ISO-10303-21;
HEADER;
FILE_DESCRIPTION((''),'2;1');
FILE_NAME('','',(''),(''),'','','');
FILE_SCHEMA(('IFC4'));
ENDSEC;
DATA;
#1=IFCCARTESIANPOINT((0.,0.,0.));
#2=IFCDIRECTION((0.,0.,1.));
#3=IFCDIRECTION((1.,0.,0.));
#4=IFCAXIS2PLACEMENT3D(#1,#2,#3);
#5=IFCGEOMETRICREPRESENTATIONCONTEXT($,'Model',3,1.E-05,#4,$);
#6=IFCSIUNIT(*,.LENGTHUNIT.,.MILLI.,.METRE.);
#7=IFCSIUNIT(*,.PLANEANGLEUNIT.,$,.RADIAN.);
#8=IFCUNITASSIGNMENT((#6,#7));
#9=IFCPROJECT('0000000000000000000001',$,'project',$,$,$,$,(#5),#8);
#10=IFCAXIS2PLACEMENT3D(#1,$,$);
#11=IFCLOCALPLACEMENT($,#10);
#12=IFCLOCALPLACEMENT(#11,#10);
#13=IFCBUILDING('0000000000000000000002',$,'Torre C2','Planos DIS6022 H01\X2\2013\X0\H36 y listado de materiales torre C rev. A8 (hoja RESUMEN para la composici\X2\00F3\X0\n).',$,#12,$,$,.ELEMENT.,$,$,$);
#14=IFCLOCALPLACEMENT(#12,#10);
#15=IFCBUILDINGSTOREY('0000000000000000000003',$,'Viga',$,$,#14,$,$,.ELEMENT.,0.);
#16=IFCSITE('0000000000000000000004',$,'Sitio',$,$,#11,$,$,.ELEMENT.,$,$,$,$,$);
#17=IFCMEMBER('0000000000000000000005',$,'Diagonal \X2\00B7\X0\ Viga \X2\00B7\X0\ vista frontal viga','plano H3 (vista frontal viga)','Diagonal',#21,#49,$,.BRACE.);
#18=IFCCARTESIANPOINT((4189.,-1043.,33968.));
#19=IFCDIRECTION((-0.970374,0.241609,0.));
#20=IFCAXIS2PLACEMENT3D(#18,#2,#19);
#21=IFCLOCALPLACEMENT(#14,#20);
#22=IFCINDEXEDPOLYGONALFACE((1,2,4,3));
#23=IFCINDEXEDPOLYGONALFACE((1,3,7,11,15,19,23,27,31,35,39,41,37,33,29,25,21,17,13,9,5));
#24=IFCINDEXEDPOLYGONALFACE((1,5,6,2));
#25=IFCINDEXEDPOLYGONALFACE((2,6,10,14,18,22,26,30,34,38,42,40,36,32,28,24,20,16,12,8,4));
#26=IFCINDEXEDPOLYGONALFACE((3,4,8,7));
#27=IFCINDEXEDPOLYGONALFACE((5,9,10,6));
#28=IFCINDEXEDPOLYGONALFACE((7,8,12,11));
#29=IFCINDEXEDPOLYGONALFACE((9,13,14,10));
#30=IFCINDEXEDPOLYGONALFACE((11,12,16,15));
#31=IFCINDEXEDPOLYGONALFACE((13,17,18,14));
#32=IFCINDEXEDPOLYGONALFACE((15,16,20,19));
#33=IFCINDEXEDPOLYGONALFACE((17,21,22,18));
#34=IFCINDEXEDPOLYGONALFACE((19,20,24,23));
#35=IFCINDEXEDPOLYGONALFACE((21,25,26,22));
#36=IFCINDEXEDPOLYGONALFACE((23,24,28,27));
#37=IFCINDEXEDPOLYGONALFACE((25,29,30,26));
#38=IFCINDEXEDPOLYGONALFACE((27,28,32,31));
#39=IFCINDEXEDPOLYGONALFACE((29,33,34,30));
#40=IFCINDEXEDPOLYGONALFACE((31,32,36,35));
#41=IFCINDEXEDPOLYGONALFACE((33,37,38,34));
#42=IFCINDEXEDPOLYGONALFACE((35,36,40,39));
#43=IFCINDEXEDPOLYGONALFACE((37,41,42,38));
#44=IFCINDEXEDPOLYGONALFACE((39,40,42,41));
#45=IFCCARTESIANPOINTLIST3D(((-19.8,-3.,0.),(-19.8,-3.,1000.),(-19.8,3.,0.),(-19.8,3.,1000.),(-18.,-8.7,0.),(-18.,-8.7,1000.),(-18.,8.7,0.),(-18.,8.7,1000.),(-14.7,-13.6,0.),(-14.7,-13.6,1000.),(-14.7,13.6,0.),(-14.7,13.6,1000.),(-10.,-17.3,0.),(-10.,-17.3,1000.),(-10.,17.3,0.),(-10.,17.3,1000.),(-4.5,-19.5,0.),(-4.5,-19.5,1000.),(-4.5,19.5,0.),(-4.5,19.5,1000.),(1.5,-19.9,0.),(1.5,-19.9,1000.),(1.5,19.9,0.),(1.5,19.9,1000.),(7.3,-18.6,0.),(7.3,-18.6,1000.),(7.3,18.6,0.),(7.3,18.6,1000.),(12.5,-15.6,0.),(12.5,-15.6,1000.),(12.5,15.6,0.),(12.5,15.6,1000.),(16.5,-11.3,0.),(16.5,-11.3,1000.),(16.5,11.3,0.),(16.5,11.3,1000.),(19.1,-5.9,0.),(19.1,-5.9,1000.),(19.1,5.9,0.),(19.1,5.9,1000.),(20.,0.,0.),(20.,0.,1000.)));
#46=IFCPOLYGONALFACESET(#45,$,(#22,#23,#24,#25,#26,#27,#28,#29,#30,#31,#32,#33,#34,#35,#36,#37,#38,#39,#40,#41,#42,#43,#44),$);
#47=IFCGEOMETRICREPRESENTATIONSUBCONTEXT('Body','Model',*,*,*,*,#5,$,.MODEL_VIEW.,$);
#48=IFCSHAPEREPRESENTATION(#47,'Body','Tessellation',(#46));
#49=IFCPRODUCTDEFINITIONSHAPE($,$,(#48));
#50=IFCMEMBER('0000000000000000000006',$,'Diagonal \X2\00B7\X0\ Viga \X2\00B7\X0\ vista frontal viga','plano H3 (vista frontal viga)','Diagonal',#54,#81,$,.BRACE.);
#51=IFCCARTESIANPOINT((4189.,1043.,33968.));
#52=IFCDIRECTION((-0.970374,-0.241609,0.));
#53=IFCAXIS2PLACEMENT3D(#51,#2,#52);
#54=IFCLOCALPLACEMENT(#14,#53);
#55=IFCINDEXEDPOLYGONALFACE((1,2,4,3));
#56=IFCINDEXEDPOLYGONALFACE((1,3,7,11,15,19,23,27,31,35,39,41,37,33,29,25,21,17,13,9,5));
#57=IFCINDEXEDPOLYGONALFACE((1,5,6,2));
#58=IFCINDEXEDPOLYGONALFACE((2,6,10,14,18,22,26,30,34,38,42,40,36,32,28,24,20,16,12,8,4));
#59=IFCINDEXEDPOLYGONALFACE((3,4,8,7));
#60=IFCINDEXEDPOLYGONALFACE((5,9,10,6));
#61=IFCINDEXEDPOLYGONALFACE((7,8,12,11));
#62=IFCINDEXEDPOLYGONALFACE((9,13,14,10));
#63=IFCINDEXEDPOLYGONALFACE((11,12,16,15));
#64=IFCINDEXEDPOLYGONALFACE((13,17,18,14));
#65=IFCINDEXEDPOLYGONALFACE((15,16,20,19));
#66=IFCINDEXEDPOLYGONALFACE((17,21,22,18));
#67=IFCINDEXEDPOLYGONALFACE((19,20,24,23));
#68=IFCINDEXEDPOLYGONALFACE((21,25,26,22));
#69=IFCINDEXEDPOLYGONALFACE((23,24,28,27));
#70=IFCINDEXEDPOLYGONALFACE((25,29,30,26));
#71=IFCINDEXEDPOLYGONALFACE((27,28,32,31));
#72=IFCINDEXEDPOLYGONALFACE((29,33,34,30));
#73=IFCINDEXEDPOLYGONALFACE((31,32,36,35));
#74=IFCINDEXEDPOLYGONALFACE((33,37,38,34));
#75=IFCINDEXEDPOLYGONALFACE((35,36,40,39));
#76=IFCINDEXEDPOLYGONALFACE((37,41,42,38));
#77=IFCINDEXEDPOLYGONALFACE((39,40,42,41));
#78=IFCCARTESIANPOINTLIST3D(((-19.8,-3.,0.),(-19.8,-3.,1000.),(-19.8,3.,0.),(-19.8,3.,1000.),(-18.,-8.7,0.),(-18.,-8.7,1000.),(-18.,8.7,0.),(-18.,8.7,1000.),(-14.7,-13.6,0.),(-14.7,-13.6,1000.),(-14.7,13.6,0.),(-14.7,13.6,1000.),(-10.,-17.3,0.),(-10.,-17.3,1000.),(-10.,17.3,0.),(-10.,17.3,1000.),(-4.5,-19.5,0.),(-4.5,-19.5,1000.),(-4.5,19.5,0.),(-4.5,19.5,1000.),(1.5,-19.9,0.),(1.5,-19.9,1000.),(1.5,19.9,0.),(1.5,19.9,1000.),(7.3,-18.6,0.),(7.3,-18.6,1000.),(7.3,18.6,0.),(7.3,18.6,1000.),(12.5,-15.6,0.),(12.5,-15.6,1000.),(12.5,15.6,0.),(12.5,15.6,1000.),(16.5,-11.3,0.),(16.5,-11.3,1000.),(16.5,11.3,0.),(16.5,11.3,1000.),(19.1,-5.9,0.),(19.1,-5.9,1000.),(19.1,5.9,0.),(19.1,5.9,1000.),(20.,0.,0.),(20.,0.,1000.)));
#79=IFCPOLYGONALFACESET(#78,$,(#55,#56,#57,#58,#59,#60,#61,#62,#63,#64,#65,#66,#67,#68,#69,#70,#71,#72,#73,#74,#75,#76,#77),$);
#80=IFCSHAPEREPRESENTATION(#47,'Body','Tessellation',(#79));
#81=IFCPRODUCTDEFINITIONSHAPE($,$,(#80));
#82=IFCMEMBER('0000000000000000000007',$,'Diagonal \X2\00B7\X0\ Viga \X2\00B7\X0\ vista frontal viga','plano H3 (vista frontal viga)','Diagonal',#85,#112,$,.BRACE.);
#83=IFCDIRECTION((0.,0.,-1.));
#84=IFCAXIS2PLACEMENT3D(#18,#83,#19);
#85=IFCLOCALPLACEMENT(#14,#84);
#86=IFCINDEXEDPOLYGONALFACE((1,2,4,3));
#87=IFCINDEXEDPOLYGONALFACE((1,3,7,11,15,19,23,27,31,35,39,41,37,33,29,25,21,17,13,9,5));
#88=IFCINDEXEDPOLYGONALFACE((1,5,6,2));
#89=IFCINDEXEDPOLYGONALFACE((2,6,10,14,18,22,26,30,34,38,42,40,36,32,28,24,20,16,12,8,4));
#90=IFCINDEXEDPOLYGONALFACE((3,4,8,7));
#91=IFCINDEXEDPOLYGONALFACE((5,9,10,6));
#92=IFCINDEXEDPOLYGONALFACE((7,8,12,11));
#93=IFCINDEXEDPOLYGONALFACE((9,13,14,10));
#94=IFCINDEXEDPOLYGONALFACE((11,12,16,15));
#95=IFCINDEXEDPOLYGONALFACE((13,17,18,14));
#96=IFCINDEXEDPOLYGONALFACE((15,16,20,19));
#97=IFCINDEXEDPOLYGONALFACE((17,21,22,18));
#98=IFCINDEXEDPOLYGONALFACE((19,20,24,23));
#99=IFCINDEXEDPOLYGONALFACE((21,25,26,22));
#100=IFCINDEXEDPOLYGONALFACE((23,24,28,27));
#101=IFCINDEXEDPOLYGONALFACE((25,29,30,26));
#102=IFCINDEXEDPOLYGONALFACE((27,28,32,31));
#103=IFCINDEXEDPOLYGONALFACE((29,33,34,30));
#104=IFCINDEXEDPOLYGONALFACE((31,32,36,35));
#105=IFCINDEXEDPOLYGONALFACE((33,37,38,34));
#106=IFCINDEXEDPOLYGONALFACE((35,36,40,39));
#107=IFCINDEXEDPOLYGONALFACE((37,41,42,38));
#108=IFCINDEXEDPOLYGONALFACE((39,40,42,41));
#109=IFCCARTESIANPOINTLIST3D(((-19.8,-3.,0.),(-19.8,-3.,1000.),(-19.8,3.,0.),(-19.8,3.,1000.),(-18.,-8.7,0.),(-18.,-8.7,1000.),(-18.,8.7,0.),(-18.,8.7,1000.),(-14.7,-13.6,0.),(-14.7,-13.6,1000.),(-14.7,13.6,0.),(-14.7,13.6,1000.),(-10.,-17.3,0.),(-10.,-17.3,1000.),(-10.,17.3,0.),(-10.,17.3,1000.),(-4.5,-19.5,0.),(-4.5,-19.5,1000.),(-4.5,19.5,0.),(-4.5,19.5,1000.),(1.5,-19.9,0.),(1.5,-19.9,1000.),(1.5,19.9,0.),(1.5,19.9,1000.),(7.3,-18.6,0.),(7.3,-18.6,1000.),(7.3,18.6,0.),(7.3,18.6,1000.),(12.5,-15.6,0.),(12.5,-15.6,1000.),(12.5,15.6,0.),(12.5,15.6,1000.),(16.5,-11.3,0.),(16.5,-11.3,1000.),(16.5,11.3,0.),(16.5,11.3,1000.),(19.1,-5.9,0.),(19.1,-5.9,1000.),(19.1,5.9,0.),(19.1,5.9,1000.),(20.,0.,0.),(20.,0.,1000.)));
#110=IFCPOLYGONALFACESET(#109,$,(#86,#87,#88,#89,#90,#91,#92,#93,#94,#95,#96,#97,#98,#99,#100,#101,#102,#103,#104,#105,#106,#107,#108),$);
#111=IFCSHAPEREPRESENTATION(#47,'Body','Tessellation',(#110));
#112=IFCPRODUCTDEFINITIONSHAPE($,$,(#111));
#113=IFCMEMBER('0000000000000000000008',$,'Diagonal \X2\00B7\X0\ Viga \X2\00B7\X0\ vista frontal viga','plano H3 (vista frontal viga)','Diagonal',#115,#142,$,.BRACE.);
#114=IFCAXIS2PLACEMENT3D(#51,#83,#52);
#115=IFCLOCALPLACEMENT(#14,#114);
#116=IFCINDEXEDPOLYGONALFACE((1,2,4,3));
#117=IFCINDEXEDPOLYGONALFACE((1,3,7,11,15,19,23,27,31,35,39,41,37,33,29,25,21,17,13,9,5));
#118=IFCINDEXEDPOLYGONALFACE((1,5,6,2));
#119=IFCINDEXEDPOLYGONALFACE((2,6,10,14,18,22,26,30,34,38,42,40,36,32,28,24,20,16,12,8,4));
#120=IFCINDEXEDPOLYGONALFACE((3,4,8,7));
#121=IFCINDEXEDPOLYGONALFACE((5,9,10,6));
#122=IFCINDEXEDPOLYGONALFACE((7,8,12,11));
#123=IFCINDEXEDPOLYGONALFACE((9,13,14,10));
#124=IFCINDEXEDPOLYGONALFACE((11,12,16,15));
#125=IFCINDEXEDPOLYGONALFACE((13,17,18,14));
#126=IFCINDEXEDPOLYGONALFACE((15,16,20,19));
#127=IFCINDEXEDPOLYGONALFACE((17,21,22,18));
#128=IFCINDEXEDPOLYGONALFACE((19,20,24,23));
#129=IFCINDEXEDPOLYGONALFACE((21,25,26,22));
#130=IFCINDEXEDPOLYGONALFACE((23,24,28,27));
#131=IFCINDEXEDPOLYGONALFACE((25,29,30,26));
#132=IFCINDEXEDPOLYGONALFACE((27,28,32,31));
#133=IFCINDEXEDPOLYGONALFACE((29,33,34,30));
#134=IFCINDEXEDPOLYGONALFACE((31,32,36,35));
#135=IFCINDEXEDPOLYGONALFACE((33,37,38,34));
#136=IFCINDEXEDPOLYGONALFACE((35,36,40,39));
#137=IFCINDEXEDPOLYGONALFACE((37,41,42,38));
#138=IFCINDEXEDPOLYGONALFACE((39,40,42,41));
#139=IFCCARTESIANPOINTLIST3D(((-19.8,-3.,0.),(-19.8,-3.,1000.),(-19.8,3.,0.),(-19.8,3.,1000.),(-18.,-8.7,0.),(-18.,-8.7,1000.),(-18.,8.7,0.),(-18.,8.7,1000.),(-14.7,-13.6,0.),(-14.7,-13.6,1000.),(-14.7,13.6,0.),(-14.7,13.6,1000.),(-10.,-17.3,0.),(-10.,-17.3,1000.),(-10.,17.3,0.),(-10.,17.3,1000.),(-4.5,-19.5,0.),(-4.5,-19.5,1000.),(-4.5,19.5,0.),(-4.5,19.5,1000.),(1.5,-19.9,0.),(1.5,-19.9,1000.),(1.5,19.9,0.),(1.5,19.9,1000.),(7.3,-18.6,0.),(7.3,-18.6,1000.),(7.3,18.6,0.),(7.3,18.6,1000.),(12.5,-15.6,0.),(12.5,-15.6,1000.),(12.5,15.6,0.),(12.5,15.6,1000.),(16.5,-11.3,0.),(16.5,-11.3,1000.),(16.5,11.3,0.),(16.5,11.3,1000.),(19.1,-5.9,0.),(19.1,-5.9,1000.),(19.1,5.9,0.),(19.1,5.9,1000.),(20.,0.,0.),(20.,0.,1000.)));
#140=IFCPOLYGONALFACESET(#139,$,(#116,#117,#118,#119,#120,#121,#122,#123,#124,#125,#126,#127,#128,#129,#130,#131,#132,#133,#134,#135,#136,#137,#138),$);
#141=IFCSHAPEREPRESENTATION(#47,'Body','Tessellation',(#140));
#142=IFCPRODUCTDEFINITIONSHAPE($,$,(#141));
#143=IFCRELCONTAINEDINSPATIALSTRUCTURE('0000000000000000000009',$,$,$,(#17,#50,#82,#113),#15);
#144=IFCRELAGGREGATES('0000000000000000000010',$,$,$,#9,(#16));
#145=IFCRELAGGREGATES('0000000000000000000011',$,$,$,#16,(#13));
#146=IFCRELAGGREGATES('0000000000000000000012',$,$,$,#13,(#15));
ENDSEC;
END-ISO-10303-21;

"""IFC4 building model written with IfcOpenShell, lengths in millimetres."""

from ifc_helpers import new_model, si_unit, frame, origin, origin_with_axes, place, context, subcontext, project, spatial, circle, extrude, element, save


model = new_model("IFC4")

# Units and contexts
model_context = context("Model", 3, precision=1e-05, world=origin_with_axes())
body_context = subcontext(model_context, "Body", "Model", "MODEL_VIEW")
ifc_project = project(units=[si_unit("LENGTHUNIT", "METRE", prefix="MILLI"), si_unit("PLANEANGLEUNIT", "RADIAN")], contexts=[model_context])

# Site, building, storey
site_placement = place(None, origin())
site = spatial("IfcSite", under=ifc_project, at=site_placement, Name="Sitio", CompositionType="ELEMENT")
building_placement = place(site_placement, origin())
building = spatial("IfcBuilding", under=site, at=building_placement, Name="Torre C2", Description="Planos DIS6022 H01–H36 y listado de materiales torre C rev. A8 (hoja RESUMEN para la composición).", CompositionType="ELEMENT")
storey_placement = place(building_placement, origin())
storey = spatial("IfcBuildingStorey", under=building, at=storey_placement, Name="Viga", CompositionType="ELEMENT", Elevation=0.0)

# Members
for number, where, z_axis, x_axis, name in (
    (1, (4189.0, -1043.0, 33968.0), (0.0, 0.0, 1.0), (-0.970374, 0.241609, 0.0), "Diagonal · Viga · vista frontal viga"),
    (2, (4189.0, 1043.0, 33968.0), (0.0, 0.0, 1.0), (-0.970374, -0.241609, 0.0), "Diagonal · Viga · vista frontal viga"),
    (3, (4189.0, -1043.0, 33968.0), (0.0, 0.0, -1.0), (-0.970374, 0.241609, 0.0), "Diagonal · Viga · vista frontal viga"),
    (4, (4189.0, 1043.0, 33968.0), (0.0, 0.0, -1.0), (-0.970374, -0.241609, 0.0), "Diagonal · Viga · vista frontal viga"),
):
    element("IfcMember", number, at=place(storey_placement, frame(where, z_axis=z_axis, x_axis=x_axis)), inside=storey, Name=name, Description="plano H3 (vista frontal viga)", ObjectType="Diagonal", PredefinedType="BRACE", context=body_context, shape_type="SweptSolid", body=[
        extrude(circle(Radius=20.0), None, (0.0, 0.0, 1.0), 1000.0),
    ])

save(model, "model.ifc")
